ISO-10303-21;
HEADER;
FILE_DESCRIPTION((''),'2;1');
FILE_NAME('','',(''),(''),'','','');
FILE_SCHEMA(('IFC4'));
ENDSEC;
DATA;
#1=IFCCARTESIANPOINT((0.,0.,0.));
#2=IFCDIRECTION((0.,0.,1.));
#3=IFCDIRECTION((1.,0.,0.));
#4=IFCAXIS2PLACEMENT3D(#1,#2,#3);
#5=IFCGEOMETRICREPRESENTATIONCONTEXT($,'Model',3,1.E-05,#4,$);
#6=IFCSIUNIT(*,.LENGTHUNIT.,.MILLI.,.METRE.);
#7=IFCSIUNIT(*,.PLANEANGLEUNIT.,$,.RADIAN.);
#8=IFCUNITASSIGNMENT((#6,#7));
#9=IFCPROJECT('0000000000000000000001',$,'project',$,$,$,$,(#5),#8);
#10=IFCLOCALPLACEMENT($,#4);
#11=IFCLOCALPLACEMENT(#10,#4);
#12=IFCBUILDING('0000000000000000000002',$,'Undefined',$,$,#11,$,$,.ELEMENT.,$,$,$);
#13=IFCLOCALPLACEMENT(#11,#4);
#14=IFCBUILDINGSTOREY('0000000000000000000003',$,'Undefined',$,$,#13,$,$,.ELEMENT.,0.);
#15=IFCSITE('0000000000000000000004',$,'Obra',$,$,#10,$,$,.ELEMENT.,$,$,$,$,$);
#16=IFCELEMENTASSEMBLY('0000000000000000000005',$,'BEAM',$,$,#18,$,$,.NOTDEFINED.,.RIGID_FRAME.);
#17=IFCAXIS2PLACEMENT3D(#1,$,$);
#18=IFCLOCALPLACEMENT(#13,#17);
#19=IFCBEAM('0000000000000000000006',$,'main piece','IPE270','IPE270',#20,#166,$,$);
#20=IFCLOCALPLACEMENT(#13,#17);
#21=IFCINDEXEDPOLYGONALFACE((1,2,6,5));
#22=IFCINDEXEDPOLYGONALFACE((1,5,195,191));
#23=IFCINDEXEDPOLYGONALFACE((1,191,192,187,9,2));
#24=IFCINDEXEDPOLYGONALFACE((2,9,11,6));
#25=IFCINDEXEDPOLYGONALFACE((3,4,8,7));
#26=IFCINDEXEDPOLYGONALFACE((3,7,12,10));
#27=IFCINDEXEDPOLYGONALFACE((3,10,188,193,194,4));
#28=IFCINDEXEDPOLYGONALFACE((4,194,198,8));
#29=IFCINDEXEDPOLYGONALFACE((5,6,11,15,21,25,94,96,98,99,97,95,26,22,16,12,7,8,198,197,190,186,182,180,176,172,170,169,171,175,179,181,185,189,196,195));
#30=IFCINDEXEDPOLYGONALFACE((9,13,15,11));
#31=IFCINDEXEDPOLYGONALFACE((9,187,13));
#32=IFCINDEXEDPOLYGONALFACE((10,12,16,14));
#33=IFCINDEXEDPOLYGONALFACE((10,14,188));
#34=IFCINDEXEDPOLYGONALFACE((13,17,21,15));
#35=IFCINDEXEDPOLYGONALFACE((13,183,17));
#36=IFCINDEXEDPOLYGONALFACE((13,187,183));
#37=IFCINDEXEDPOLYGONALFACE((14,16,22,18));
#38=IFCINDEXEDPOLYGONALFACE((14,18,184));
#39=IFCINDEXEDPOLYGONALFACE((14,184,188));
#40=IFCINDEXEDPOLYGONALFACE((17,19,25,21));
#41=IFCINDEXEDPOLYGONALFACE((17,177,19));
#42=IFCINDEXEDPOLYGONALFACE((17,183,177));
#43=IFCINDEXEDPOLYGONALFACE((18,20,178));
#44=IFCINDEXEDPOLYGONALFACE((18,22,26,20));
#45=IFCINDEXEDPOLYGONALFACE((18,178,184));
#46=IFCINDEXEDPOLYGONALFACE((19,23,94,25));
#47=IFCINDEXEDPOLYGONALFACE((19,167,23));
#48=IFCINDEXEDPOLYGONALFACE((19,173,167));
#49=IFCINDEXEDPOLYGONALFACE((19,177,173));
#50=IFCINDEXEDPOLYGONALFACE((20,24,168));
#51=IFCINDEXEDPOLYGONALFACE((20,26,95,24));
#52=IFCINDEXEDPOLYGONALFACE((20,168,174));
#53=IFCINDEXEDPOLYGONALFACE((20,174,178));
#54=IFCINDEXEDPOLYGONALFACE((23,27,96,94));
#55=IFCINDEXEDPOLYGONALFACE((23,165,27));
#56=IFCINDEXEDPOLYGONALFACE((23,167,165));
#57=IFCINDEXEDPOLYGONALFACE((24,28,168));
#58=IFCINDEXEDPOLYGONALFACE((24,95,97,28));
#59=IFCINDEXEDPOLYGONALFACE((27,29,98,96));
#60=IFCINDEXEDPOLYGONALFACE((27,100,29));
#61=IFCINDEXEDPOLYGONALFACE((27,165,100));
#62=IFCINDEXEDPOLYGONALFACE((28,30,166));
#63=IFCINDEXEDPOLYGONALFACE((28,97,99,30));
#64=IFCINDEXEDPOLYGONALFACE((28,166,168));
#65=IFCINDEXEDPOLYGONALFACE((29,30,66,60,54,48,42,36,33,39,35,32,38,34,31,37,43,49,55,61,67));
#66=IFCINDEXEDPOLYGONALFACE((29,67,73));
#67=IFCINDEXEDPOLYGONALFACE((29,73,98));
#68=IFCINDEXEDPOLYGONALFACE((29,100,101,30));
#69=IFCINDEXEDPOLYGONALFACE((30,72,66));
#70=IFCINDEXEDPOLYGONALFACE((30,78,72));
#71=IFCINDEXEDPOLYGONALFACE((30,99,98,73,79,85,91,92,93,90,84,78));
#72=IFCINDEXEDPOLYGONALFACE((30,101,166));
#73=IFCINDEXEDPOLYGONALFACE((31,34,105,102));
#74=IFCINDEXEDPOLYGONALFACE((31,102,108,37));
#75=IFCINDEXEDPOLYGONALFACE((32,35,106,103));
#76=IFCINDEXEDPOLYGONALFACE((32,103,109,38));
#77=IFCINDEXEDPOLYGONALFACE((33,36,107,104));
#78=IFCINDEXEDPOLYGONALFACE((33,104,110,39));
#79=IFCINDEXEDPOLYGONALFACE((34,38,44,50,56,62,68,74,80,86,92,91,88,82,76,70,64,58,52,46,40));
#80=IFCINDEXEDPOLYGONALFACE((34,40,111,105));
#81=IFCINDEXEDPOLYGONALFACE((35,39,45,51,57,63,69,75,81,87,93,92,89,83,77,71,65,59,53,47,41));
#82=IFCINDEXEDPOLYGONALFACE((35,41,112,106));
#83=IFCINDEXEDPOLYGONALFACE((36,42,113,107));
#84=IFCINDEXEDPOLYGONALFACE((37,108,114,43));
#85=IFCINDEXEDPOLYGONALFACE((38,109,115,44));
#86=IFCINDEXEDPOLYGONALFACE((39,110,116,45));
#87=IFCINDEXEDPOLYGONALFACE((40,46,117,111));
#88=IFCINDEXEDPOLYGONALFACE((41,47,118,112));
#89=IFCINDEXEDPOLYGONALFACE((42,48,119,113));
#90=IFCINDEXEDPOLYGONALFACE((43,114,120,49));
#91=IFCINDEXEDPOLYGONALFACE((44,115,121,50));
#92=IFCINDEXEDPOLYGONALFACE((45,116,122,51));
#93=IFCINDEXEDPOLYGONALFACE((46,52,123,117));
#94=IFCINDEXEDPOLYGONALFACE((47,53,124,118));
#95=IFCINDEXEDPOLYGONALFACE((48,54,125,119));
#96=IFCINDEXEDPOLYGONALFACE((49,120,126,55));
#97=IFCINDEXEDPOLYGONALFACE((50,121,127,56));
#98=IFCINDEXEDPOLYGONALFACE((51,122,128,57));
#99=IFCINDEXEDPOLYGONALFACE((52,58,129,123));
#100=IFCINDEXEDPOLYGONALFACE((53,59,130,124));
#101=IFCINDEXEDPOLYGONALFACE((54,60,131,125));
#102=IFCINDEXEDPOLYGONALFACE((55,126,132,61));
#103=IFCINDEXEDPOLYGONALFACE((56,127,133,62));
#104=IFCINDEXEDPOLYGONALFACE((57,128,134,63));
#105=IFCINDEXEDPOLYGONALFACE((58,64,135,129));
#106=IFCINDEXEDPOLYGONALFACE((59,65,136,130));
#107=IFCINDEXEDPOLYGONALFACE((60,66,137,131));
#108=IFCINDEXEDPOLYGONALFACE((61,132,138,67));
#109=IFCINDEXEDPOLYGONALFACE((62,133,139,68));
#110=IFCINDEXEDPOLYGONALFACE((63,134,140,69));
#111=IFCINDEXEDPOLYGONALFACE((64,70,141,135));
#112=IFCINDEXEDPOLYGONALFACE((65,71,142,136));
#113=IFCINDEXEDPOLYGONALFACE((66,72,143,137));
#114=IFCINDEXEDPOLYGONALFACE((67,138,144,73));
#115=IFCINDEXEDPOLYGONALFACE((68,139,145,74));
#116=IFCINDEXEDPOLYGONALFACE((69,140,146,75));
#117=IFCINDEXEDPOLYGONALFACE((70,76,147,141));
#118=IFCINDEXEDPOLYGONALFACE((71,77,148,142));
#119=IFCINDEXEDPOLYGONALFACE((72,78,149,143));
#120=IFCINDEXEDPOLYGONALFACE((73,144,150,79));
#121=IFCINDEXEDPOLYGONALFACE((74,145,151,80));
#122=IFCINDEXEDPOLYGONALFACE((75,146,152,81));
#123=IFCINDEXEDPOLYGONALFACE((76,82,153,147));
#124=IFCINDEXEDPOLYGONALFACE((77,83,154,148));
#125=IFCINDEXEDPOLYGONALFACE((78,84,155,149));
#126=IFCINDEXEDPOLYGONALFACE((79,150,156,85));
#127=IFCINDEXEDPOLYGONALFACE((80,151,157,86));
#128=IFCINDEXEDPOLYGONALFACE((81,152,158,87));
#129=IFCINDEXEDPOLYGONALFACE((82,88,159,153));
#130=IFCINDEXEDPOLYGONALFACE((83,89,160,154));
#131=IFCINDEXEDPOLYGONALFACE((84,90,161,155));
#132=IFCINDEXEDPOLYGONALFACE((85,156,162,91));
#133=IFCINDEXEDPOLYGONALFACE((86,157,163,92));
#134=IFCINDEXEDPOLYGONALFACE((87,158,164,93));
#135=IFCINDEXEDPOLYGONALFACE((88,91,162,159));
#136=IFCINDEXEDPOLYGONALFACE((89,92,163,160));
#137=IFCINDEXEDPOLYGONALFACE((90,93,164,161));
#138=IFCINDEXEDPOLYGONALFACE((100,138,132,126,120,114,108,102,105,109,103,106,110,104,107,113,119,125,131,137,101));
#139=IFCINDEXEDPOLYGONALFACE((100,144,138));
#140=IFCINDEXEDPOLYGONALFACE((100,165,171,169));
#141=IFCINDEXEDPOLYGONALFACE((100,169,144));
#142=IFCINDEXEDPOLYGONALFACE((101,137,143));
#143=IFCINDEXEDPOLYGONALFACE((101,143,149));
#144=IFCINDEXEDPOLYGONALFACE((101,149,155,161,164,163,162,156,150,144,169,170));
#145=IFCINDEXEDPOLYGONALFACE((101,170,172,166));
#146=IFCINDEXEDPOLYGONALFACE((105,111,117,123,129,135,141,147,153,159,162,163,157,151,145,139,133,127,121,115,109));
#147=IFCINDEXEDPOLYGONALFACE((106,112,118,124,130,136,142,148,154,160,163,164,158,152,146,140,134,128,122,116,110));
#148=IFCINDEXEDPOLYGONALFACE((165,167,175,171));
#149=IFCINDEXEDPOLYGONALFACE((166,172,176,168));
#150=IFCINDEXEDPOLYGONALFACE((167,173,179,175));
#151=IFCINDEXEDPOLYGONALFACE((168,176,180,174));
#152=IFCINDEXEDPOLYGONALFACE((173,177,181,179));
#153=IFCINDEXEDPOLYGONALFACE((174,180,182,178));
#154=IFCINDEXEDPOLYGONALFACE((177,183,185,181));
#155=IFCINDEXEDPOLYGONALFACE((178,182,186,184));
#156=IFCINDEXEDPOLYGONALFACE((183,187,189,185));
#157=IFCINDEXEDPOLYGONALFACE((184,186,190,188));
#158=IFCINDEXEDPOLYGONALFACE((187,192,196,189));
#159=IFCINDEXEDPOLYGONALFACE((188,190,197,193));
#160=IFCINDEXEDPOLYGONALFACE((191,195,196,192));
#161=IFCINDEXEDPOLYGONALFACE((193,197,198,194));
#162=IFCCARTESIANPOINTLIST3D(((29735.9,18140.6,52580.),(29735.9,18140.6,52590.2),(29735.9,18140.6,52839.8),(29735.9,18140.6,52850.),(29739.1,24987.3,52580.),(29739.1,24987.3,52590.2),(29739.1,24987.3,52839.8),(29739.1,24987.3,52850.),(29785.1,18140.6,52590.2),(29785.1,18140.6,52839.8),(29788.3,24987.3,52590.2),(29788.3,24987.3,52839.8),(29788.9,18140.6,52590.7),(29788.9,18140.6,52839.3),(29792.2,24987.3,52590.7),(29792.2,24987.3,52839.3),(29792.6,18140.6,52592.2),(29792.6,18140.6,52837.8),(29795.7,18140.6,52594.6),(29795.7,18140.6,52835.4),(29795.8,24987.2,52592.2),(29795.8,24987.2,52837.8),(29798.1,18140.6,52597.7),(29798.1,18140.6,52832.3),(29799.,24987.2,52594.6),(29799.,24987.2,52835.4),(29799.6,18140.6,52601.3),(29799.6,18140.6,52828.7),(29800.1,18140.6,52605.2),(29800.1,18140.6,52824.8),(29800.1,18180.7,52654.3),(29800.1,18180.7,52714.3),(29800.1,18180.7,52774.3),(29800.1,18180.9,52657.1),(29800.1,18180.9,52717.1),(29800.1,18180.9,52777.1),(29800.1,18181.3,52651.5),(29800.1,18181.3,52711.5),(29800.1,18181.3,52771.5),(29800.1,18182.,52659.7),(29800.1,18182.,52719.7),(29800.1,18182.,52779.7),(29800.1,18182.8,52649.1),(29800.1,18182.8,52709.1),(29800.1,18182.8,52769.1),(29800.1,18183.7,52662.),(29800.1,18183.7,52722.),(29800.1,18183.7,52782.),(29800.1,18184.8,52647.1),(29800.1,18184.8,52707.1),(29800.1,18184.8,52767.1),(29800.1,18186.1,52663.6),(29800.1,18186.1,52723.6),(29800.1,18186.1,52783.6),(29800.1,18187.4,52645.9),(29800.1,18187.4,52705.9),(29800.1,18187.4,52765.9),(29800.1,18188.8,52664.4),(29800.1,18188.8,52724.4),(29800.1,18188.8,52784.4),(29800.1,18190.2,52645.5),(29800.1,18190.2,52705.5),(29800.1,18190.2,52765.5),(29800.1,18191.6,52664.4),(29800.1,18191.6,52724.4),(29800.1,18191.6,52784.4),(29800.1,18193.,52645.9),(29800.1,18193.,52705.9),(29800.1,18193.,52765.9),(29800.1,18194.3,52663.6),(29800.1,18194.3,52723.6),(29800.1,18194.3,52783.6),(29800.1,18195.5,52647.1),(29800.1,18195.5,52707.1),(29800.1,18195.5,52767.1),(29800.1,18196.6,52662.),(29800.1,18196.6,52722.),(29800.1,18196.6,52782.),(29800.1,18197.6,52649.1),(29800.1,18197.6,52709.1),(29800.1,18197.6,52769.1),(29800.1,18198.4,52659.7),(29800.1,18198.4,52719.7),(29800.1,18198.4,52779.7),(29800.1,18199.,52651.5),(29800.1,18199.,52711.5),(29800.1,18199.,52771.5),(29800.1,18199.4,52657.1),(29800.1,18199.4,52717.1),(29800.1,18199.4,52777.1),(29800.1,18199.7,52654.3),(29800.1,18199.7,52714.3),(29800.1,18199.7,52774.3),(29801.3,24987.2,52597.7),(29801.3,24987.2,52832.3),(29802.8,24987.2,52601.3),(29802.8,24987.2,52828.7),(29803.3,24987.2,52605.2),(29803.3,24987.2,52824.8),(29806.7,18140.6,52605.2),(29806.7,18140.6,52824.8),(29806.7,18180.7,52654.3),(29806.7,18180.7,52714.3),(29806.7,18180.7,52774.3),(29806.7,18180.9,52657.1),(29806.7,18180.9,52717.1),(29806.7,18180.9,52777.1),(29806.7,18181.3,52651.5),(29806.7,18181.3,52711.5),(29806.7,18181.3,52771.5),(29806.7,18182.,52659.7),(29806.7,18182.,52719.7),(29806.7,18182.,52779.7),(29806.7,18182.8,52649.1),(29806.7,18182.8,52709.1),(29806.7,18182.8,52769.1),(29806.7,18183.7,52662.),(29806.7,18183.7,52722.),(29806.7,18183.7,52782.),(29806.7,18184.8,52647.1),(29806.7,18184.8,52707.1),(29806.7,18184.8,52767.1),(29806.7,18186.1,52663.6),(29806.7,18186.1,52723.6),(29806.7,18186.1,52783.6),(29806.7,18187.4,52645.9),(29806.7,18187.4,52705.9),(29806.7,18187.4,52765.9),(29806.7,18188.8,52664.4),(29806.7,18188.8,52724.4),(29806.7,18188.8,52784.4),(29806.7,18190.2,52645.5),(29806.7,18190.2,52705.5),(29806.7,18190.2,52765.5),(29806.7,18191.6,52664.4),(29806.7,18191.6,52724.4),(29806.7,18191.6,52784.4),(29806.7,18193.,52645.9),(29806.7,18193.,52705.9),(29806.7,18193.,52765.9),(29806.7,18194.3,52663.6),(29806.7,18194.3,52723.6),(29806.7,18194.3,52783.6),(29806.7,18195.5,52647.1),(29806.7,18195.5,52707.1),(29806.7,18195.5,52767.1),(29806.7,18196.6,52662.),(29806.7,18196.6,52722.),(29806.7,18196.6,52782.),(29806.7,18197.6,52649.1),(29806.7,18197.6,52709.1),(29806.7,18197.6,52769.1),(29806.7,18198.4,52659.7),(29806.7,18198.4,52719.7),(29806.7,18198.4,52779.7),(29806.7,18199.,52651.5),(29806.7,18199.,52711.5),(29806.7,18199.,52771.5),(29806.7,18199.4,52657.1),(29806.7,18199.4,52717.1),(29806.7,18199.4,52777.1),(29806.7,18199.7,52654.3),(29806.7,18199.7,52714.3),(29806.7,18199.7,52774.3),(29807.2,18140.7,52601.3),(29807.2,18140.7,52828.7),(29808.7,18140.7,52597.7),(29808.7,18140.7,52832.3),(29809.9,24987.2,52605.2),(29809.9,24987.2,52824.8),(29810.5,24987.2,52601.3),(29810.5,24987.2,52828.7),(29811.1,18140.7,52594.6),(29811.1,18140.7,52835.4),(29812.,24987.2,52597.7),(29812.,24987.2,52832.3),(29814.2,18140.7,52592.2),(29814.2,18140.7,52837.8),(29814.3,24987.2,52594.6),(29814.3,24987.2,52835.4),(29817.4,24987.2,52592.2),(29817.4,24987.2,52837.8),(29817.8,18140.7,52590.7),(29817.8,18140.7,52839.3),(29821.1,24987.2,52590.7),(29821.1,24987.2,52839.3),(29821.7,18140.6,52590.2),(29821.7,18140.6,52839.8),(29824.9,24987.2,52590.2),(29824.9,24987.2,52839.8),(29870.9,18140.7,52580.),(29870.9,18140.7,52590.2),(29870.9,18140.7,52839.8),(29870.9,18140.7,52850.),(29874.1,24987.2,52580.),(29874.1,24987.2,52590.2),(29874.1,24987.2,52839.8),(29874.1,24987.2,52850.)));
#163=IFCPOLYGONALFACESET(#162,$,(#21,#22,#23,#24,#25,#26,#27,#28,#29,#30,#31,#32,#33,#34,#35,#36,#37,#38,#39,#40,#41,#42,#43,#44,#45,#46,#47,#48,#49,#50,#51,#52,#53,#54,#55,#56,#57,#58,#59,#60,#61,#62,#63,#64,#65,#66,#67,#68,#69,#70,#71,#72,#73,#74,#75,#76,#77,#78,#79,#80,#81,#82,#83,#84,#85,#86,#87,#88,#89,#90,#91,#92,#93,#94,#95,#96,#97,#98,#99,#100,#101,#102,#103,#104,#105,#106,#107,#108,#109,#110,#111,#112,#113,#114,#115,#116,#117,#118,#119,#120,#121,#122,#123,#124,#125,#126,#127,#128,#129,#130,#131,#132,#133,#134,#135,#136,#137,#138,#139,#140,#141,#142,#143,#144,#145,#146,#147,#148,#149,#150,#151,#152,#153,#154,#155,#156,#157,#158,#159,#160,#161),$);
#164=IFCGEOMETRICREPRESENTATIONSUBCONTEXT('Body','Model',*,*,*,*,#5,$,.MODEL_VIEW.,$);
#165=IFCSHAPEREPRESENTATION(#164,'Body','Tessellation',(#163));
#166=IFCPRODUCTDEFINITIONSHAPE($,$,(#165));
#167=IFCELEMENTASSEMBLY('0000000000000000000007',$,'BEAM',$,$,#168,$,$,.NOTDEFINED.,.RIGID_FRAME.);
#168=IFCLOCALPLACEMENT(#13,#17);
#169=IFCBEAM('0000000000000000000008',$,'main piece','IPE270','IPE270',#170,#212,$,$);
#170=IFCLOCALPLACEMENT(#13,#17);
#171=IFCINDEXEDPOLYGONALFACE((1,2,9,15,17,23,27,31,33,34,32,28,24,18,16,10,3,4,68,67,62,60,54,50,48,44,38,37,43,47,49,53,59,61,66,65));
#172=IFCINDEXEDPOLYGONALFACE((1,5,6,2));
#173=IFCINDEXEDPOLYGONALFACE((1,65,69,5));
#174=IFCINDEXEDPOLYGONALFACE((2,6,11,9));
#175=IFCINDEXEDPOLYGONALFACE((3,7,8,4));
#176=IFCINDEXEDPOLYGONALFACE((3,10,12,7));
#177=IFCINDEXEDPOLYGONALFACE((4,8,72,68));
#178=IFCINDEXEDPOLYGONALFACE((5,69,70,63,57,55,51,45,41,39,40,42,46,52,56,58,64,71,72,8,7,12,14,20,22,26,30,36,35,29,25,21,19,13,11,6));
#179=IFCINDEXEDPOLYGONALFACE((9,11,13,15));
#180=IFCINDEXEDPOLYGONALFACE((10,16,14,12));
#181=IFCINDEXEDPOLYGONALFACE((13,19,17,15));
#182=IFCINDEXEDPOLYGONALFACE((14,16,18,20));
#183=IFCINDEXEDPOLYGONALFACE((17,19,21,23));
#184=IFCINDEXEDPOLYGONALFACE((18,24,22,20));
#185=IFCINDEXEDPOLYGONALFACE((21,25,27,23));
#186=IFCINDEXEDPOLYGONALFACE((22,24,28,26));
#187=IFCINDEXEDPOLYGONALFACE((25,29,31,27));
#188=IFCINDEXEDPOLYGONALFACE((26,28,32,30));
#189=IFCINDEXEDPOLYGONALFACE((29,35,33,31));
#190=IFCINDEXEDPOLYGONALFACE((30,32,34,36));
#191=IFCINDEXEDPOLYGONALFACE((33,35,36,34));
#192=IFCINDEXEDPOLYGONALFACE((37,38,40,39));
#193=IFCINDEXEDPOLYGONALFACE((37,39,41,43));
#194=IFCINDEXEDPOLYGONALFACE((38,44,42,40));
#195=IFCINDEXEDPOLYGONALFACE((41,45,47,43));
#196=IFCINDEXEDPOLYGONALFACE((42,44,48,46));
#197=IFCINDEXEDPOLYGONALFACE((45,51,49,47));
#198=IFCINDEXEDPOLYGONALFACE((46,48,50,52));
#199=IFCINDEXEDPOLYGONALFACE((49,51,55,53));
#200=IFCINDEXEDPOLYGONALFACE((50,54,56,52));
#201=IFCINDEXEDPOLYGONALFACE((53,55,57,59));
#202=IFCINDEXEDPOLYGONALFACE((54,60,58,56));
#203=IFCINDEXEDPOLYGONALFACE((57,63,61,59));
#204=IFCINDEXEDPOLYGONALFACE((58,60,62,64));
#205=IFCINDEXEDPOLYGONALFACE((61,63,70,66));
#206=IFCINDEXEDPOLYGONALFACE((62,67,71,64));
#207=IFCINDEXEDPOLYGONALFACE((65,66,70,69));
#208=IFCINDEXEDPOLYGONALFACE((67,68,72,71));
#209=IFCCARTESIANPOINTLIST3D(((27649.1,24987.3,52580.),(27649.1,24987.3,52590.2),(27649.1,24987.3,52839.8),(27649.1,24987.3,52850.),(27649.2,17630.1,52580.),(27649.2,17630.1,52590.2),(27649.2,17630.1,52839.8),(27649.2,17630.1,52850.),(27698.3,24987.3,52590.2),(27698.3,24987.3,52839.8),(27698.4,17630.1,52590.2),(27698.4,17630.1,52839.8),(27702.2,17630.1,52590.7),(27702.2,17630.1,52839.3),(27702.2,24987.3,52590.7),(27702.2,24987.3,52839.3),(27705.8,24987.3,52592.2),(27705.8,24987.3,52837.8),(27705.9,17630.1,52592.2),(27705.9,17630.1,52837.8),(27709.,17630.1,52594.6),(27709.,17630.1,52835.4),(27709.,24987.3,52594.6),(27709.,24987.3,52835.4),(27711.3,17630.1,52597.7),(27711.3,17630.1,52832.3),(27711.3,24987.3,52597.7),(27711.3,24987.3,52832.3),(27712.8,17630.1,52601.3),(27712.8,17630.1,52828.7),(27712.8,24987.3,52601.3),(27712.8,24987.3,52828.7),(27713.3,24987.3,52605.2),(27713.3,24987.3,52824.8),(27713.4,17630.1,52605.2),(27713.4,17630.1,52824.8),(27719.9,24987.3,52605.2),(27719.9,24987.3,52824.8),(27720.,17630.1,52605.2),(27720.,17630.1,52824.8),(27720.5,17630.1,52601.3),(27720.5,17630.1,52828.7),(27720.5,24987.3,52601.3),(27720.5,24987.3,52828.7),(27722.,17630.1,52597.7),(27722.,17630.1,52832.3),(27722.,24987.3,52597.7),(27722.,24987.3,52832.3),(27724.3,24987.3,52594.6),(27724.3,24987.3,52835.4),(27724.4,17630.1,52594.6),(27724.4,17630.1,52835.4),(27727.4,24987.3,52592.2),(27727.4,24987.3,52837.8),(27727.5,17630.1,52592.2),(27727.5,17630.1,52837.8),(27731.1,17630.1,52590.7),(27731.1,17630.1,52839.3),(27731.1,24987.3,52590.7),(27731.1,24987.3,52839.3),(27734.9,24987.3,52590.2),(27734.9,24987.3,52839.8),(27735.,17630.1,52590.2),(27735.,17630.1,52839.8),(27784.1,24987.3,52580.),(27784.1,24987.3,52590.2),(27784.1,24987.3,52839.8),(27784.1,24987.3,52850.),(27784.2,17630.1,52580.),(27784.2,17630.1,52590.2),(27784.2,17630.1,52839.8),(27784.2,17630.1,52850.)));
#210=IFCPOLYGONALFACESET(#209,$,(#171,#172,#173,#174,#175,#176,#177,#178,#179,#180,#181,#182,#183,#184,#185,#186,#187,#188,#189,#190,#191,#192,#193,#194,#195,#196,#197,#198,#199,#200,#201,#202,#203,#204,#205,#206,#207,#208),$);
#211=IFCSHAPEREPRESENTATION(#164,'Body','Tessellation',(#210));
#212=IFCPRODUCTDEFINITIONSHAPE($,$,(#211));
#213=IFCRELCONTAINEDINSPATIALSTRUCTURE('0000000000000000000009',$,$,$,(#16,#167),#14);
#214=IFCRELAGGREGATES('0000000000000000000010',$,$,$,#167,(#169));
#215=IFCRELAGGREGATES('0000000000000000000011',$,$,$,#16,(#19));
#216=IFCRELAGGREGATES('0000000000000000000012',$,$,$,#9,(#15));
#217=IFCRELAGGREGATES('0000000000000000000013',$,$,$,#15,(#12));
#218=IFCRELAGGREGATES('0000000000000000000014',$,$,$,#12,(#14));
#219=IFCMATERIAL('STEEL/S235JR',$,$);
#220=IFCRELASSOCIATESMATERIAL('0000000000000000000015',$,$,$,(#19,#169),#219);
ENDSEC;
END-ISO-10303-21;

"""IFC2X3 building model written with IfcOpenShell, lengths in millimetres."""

from ifc_helpers import new_model, si_unit, frame, origin_with_axes, origin_2d_with_axis, place, context, subcontext, project, spatial, circle, i_section, extrude, clip, halfspace, source, transform, mapped, material, element, aggregate, save


model = new_model("IFC2X3")

# Units and contexts
model_context = context("Model", 3, precision=1e-05, world=origin_with_axes())
body_context = subcontext(model_context, "Body", "Model", "MODEL_VIEW")
ifc_project = project(units=[si_unit("LENGTHUNIT", "METRE", prefix="MILLI"), si_unit("PLANEANGLEUNIT", "RADIAN")], contexts=[model_context])

# Site, building, storey
site_placement = place(None, origin_with_axes())
site = spatial("IfcSite", under=ifc_project, at=site_placement, Name="Obra", CompositionType="ELEMENT")
building_placement = place(site_placement, origin_with_axes())
building = spatial("IfcBuilding", under=site, at=building_placement, Name="Undefined", CompositionType="ELEMENT")
storey_placement = place(building_placement, origin_with_axes())
storey = spatial("IfcBuildingStorey", under=building, at=storey_placement, Name="Undefined", CompositionType="ELEMENT", Elevation=0.0)

# Shared definitions
ifc_material_1 = material(Name="STEEL/S235JR")

# Element assembly, beam, opening
shared_shape_1 = source(origin_with_axes(), body_context, "Body", "SweptSolid", [
    extrude(circle(Radius=9.5, at=origin_2d_with_axis()), frame((0.0, -3.7, 0.0), z_axis=(0.0, 1.0, 0.0), x_axis=(1.0, 0.0, 0.0)), (0.0, 0.0, 1.0), 6.8),
])
assembly_1_placement = place(storey_placement, origin_with_axes())
assembly_1 = element("IfcElementAssembly", 1, at=assembly_1_placement, inside=storey, Name="BEAM", AssemblyPlace="NOTDEFINED", PredefinedType="RIGID_FRAME")
beam_1_placement = place(assembly_1_placement, frame((29803.4, 18130.2, 52715.0), z_axis=(0.0, 0.0, 1.0), x_axis=(0.00048, 1.0, 0.0)))
beam_1 = element("IfcBeam", 2, at=beam_1_placement, material=ifc_material_1, Name="main piece", Description="IPE270", ObjectType="IPE270", context=body_context, shape_type="Clipping", body=[
    clip(extrude(i_section(OverallWidth=135.0, OverallDepth=270.0, WebThickness=6.6, FlangeThickness=10.2, FilletRadius=15.0, at=origin_2d_with_axis()), frame((6857.1, 0.0, 0.0), z_axis=(-1.0, 0.0, 0.0), x_axis=(0.0, -1.0, 0.0)), (0.0, 0.0, 1.0), 6857.1), halfspace(frame((10.5, 60.3, -120.0), z_axis=(-1.0, -0.0005, 0.0), x_axis=(0.0, 0.0, 1.0)), False)),
])
opening_1_placement = place(assembly_1_placement, frame((29803.1, 18140.2, 52835.0), z_axis=(-0.000002, 1.0, 0.0), x_axis=(0.0, 0.0, -1.0)))
element("IfcOpeningElement", 3, at=opening_1_placement, cuts=beam_1, ObjectType="Opening", context=body_context, shape_type="MappedRepresentation", body=[
    mapped(shared_shape_1, transform((60.0, 0.0, 50.0))),
    mapped(shared_shape_1, transform((120.0, 0.0, 50.0))),
    mapped(shared_shape_1, transform((180.0, 0.0, 50.0))),
])

# Element assembly, beam
assembly_2_placement = place(storey_placement, origin_with_axes())
assembly_2 = element("IfcElementAssembly", 4, at=assembly_2_placement, inside=storey, Name="BEAM", AssemblyPlace="NOTDEFINED", PredefinedType="RIGID_FRAME")
beam_2_placement = place(assembly_2_placement, frame((27716.7, 17630.1, 52715.0), z_axis=(0.0, 0.0, 1.0), x_axis=(-0.000002, 1.0, 0.0)))
beam_2 = element("IfcBeam", 5, at=beam_2_placement, material=ifc_material_1, Name="main piece", Description="IPE270", ObjectType="IPE270", context=body_context, shape_type="SweptSolid", body=[
    extrude(i_section(OverallWidth=135.0, OverallDepth=270.0, WebThickness=6.6, FlangeThickness=10.2, FilletRadius=15.0, at=origin_2d_with_axis()), frame((7357.1, 0.0, 0.0), z_axis=(-1.0, 0.0, 0.0), x_axis=(0.0, -1.0, 0.0)), (0.0, 0.0, 1.0), 7357.1),
])
aggregate(assembly_2, [beam_2])

aggregate(assembly_1, [beam_1])

save(model, "model.ifc")
